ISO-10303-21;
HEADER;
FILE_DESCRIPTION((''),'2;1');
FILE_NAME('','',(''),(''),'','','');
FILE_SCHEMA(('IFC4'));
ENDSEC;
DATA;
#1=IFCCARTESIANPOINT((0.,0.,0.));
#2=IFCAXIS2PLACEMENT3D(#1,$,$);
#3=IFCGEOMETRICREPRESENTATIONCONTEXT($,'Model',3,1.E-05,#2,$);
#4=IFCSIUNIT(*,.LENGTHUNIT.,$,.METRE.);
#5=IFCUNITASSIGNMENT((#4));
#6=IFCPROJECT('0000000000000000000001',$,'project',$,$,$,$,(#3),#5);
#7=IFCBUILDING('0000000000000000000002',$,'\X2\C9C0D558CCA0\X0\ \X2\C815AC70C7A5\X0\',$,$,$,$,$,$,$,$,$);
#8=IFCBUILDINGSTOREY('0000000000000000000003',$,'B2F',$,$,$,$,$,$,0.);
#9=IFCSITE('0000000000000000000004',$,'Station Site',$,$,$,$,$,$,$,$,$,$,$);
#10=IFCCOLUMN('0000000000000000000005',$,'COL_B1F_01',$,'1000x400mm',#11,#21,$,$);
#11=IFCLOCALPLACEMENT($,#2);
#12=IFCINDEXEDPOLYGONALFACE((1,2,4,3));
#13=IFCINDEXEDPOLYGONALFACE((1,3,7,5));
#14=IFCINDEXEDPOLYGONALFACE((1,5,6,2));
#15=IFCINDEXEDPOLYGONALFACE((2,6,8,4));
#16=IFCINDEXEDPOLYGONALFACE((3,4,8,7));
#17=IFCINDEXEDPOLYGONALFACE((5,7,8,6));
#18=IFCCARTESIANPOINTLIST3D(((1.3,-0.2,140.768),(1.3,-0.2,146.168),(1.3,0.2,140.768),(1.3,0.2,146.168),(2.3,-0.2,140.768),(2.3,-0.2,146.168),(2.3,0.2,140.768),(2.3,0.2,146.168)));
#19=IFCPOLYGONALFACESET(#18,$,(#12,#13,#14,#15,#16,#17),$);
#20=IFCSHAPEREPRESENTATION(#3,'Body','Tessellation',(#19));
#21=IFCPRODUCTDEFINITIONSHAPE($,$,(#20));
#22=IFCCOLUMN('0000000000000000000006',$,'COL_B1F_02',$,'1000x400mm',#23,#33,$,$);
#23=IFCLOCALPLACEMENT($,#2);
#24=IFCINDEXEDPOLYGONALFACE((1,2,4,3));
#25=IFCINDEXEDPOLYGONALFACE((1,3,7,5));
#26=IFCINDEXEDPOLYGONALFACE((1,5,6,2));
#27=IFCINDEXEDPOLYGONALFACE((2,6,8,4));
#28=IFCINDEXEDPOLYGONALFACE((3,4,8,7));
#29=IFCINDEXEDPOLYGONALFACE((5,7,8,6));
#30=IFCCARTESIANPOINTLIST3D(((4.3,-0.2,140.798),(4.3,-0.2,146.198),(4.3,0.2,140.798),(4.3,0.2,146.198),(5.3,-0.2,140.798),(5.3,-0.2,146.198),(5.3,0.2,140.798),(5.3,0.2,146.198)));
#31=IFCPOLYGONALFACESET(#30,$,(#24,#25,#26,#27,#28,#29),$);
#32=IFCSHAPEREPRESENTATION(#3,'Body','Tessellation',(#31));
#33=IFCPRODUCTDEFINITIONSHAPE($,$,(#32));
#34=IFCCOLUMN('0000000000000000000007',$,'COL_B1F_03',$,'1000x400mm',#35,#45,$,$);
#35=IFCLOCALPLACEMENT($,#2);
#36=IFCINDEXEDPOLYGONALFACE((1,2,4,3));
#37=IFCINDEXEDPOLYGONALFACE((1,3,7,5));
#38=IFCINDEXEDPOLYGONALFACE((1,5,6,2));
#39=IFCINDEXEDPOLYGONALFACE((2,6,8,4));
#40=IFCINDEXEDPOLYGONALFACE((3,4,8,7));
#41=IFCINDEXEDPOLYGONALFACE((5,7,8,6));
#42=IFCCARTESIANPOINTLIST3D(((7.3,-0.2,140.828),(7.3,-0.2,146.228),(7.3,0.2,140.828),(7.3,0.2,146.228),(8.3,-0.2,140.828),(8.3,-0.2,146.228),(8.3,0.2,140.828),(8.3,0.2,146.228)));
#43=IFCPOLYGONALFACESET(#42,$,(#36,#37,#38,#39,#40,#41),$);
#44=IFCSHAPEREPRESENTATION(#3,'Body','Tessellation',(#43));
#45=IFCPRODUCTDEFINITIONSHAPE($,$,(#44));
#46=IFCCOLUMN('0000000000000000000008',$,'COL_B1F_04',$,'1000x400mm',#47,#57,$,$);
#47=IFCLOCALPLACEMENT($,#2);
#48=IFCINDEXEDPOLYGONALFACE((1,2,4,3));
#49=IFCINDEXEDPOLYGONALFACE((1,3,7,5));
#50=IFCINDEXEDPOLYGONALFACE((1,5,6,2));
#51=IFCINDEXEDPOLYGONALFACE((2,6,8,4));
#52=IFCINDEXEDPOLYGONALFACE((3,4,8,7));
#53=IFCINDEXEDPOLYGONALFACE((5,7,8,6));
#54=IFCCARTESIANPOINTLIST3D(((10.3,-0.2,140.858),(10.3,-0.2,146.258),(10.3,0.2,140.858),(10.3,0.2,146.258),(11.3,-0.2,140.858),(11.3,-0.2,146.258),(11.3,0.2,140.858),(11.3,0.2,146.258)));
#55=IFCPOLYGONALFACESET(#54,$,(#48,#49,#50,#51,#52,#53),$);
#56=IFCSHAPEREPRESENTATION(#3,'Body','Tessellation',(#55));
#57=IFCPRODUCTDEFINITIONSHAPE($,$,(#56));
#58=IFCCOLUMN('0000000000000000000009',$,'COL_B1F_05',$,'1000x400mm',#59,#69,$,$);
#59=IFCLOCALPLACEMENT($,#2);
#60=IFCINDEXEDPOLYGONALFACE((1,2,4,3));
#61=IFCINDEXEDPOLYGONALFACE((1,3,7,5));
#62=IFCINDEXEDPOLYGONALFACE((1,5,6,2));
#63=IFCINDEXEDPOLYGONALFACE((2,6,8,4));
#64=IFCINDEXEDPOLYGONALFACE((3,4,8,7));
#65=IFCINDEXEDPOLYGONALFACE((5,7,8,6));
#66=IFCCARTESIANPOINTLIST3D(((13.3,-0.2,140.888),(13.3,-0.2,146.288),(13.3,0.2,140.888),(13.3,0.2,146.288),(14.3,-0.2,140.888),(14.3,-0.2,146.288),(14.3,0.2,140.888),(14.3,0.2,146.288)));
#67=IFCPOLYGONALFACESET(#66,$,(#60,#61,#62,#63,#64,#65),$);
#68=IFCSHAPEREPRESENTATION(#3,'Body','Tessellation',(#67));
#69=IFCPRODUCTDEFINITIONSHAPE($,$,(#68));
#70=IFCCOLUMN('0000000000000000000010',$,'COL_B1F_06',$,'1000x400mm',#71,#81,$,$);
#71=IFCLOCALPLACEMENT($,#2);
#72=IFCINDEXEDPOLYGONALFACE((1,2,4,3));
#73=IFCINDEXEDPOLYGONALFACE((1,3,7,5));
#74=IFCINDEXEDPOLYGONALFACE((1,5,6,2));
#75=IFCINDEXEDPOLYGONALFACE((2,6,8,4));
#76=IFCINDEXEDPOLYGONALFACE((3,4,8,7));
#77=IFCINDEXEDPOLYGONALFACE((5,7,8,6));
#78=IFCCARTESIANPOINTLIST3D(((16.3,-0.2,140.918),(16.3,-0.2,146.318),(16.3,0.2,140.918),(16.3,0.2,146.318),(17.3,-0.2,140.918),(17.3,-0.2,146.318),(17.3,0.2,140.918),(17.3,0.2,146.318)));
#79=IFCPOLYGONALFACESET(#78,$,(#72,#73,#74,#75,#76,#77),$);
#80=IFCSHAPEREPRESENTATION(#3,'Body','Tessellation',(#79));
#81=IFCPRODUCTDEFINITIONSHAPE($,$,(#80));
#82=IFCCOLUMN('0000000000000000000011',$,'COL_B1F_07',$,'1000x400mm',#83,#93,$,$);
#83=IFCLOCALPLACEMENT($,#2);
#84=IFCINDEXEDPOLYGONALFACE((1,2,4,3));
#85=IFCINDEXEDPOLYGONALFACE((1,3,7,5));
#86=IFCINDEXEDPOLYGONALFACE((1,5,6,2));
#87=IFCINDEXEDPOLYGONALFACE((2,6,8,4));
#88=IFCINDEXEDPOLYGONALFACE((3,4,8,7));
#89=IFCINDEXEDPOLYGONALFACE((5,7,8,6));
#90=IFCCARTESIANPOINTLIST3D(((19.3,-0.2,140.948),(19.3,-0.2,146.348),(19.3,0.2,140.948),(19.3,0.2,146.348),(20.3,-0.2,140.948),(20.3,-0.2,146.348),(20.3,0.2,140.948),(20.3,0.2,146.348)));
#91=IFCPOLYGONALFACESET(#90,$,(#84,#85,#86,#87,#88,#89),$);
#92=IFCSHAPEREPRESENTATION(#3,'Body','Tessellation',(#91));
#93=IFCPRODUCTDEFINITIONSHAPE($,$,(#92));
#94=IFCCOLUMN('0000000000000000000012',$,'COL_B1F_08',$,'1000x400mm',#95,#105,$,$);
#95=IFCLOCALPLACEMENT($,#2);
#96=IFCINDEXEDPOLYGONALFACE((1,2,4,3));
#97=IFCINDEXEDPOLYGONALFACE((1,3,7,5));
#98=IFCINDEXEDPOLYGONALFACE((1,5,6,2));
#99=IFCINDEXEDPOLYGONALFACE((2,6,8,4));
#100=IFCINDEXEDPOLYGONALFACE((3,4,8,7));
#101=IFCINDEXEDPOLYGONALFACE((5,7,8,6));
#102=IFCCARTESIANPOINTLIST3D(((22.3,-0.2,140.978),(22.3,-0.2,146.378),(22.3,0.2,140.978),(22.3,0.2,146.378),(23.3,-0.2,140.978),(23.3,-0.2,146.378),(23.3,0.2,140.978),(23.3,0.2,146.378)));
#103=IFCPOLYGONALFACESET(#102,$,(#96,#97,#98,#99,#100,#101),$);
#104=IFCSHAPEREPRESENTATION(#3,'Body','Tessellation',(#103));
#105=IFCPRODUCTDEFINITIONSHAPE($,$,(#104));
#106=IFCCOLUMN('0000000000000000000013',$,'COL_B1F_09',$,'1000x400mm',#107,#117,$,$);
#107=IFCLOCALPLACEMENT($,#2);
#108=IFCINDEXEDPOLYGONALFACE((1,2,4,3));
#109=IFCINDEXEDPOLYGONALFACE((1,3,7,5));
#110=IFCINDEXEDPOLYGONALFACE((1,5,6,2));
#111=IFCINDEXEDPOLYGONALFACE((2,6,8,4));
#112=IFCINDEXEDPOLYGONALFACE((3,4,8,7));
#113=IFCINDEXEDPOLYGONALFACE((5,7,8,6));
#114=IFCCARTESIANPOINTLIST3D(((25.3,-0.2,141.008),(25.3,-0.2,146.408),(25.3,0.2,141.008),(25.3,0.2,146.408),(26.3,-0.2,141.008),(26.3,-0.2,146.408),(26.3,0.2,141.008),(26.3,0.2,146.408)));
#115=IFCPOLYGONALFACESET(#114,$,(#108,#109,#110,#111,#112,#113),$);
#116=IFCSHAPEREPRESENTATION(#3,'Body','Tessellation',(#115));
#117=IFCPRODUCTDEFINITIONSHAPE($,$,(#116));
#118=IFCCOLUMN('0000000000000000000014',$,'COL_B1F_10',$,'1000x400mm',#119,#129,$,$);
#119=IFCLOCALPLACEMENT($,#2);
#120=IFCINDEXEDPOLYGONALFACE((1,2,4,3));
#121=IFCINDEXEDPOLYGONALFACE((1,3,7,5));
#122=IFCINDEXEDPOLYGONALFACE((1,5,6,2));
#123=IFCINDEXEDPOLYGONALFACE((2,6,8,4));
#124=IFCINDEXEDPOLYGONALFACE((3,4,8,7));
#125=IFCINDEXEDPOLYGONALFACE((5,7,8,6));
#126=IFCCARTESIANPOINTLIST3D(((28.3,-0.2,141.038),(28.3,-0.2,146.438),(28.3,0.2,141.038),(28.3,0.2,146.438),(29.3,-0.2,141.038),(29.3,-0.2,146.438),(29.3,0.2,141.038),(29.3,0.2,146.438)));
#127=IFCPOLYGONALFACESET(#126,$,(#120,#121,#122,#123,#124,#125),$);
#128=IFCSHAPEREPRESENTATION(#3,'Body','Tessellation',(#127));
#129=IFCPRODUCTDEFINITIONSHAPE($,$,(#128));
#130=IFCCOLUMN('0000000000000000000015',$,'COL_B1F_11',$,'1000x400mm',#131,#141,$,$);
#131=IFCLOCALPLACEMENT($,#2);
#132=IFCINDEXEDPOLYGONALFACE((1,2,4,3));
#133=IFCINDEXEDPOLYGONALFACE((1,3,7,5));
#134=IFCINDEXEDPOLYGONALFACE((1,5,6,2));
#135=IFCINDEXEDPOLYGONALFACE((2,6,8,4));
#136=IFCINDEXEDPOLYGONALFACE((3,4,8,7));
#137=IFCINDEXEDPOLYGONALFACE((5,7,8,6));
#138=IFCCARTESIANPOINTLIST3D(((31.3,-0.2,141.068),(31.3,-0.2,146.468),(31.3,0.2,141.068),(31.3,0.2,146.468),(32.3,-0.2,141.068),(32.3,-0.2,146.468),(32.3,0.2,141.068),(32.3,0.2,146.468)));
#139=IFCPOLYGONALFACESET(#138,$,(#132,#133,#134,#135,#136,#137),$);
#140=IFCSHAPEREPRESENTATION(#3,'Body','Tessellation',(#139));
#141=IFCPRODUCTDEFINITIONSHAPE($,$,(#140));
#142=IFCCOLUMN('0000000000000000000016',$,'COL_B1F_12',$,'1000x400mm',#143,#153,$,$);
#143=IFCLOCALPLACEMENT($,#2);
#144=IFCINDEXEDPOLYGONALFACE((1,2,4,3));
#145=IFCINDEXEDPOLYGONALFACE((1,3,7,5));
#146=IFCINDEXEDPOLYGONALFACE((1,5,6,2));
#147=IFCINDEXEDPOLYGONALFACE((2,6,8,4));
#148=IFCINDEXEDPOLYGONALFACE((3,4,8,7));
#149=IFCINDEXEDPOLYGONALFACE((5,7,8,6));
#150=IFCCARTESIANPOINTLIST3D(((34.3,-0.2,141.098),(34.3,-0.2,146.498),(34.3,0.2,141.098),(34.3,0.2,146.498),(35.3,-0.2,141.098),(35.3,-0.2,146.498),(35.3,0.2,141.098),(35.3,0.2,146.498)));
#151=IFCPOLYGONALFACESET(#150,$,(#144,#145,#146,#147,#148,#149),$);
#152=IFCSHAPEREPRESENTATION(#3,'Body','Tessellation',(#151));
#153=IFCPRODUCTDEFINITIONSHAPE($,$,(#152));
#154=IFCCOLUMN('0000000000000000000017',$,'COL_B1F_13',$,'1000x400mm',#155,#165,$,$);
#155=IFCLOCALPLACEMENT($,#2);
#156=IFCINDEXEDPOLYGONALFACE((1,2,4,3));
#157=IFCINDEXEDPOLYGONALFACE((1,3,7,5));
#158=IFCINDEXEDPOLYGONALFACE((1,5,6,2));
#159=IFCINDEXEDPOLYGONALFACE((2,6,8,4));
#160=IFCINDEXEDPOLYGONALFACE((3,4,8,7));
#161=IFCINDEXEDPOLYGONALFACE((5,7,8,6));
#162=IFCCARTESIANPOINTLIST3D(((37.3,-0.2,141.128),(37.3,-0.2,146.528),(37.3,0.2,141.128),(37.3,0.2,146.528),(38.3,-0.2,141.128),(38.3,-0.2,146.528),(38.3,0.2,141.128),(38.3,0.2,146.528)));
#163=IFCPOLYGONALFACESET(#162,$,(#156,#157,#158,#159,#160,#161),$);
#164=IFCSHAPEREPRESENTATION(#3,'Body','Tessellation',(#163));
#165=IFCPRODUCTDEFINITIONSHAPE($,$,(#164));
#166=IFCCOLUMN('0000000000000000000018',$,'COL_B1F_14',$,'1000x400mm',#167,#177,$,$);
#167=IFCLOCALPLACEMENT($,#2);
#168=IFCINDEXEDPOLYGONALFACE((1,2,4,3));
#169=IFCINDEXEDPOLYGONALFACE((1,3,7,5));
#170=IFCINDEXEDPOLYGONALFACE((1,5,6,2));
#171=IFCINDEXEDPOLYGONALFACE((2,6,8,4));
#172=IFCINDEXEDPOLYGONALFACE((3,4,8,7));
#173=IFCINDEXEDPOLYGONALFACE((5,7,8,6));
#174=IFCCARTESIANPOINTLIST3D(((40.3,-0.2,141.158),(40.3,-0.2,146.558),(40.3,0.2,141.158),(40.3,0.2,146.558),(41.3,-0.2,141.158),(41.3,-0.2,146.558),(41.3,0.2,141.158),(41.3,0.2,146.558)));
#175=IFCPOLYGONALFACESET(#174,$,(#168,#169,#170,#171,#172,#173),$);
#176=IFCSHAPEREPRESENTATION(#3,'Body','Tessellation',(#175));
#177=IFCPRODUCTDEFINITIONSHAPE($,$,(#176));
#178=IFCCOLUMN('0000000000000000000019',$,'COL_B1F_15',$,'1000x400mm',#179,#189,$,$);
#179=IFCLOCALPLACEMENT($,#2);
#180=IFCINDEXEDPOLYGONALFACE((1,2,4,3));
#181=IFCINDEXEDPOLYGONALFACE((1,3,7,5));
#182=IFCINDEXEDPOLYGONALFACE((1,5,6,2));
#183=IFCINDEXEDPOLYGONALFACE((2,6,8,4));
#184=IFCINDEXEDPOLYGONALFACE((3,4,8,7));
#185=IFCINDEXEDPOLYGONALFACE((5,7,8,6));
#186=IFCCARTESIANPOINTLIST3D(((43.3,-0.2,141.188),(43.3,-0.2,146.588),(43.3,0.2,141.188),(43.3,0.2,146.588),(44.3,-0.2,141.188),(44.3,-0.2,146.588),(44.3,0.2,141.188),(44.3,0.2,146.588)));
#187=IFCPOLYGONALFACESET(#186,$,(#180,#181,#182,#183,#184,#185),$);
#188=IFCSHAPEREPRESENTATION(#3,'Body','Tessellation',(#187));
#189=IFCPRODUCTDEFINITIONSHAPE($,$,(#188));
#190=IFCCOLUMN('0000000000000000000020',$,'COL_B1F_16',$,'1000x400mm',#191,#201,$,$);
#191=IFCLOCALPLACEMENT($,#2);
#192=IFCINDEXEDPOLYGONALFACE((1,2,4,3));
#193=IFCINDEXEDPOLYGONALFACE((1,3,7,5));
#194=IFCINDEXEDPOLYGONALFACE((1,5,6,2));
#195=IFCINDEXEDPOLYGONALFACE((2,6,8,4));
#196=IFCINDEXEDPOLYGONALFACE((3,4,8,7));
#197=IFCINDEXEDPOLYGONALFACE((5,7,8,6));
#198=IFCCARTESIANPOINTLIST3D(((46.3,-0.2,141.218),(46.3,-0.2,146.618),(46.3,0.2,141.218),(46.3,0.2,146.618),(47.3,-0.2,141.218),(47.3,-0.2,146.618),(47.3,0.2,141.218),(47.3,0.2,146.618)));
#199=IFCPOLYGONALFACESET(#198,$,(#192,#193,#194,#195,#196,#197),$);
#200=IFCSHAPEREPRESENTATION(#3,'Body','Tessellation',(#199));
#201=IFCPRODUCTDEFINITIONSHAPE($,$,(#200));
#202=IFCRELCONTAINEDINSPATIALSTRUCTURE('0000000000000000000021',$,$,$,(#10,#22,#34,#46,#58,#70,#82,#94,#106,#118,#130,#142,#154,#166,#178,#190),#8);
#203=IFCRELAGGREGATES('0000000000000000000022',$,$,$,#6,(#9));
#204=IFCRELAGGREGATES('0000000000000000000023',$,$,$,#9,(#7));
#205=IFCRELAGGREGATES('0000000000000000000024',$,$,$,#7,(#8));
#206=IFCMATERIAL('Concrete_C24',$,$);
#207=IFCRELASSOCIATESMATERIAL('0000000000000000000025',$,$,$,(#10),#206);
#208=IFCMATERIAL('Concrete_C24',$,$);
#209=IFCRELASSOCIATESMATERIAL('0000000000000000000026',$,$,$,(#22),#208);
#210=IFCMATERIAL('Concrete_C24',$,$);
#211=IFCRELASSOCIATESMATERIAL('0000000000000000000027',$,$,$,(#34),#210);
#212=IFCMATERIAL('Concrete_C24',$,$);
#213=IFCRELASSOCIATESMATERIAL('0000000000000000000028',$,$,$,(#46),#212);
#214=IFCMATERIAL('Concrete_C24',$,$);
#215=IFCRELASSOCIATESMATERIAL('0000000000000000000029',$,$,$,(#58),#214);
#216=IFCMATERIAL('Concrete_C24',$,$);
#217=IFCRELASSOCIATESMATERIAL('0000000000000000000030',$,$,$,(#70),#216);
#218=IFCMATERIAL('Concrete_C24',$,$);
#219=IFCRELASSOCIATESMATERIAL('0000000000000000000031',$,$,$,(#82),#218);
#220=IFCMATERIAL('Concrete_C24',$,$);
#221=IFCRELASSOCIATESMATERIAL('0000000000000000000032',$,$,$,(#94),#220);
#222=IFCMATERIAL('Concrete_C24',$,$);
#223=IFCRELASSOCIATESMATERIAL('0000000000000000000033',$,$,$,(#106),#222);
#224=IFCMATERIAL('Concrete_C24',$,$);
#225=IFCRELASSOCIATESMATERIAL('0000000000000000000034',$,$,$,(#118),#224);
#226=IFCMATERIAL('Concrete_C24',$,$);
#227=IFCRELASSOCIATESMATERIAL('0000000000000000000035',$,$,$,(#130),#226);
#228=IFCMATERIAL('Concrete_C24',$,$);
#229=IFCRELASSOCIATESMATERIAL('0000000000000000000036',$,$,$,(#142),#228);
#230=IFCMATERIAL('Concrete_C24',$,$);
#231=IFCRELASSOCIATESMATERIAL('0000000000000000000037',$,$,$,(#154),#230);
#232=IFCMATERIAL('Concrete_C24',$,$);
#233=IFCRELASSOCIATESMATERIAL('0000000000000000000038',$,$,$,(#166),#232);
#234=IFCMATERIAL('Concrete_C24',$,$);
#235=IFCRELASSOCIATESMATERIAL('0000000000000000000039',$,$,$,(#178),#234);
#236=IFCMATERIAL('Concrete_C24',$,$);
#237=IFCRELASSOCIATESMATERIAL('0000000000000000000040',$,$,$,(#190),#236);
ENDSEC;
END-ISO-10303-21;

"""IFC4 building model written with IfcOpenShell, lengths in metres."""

from ifc_helpers import new_model, si_unit, frame, origin, place, context, project, spatial, rectangle, extrude, material, element, save


model = new_model("IFC4")

# Units and contexts
model_context = context("Model", 3, precision=1e-05, world=origin())
ifc_project = project(units=[si_unit("LENGTHUNIT", "METRE")], contexts=[model_context])

# Site, building, storey
site = spatial("IfcSite", under=ifc_project, Name="Station Site")
building = spatial("IfcBuilding", under=site, Name="지하철 정거장")
storey = spatial("IfcBuildingStorey", under=building, Name="B2F", Elevation=0.0)

# Columns
ifc_material_1 = material(Name="Concrete_C24")
column_1_placement = place(None, frame((1.8, 0.0, 140.768)))
element("IfcColumn", 1, at=column_1_placement, inside=storey, material=ifc_material_1, Name="COL_B1F_01", ObjectType="1000x400mm", context=model_context, shape_type="SweptSolid", body=[
    extrude(rectangle(XDim=1.0, YDim=0.4), origin(), (0.0, 0.0, 1.0), 5.4),
])
ifc_material_2 = material(Name="Concrete_C24")
column_2_placement = place(None, frame((4.8, 0.0, 140.798)))
element("IfcColumn", 2, at=column_2_placement, inside=storey, material=ifc_material_2, Name="COL_B1F_02", ObjectType="1000x400mm", context=model_context, shape_type="SweptSolid", body=[
    extrude(rectangle(XDim=1.0, YDim=0.4), origin(), (0.0, 0.0, 1.0), 5.4),
])
ifc_material_3 = material(Name="Concrete_C24")
column_3_placement = place(None, frame((7.8, 0.0, 140.828)))
element("IfcColumn", 3, at=column_3_placement, inside=storey, material=ifc_material_3, Name="COL_B1F_03", ObjectType="1000x400mm", context=model_context, shape_type="SweptSolid", body=[
    extrude(rectangle(XDim=1.0, YDim=0.4), origin(), (0.0, 0.0, 1.0), 5.4),
])
ifc_material_4 = material(Name="Concrete_C24")
column_4_placement = place(None, frame((10.8, 0.0, 140.858)))
element("IfcColumn", 4, at=column_4_placement, inside=storey, material=ifc_material_4, Name="COL_B1F_04", ObjectType="1000x400mm", context=model_context, shape_type="SweptSolid", body=[
    extrude(rectangle(XDim=1.0, YDim=0.4), origin(), (0.0, 0.0, 1.0), 5.4),
])
ifc_material_5 = material(Name="Concrete_C24")
column_5_placement = place(None, frame((13.8, 0.0, 140.888)))
element("IfcColumn", 5, at=column_5_placement, inside=storey, material=ifc_material_5, Name="COL_B1F_05", ObjectType="1000x400mm", context=model_context, shape_type="SweptSolid", body=[
    extrude(rectangle(XDim=1.0, YDim=0.4), origin(), (0.0, 0.0, 1.0), 5.4),
])
ifc_material_6 = material(Name="Concrete_C24")
column_6_placement = place(None, frame((16.8, 0.0, 140.918)))
element("IfcColumn", 6, at=column_6_placement, inside=storey, material=ifc_material_6, Name="COL_B1F_06", ObjectType="1000x400mm", context=model_context, shape_type="SweptSolid", body=[
    extrude(rectangle(XDim=1.0, YDim=0.4), origin(), (0.0, 0.0, 1.0), 5.4),
])
ifc_material_7 = material(Name="Concrete_C24")
column_7_placement = place(None, frame((19.8, 0.0, 140.948)))
element("IfcColumn", 7, at=column_7_placement, inside=storey, material=ifc_material_7, Name="COL_B1F_07", ObjectType="1000x400mm", context=model_context, shape_type="SweptSolid", body=[
    extrude(rectangle(XDim=1.0, YDim=0.4), origin(), (0.0, 0.0, 1.0), 5.4),
])
ifc_material_8 = material(Name="Concrete_C24")
column_8_placement = place(None, frame((22.8, 0.0, 140.978)))
element("IfcColumn", 8, at=column_8_placement, inside=storey, material=ifc_material_8, Name="COL_B1F_08", ObjectType="1000x400mm", context=model_context, shape_type="SweptSolid", body=[
    extrude(rectangle(XDim=1.0, YDim=0.4), origin(), (0.0, 0.0, 1.0), 5.4),
])
ifc_material_9 = material(Name="Concrete_C24")
column_9_placement = place(None, frame((25.8, 0.0, 141.008)))
element("IfcColumn", 9, at=column_9_placement, inside=storey, material=ifc_material_9, Name="COL_B1F_09", ObjectType="1000x400mm", context=model_context, shape_type="SweptSolid", body=[
    extrude(rectangle(XDim=1.0, YDim=0.4), origin(), (0.0, 0.0, 1.0), 5.4),
])
ifc_material_10 = material(Name="Concrete_C24")
column_10_placement = place(None, frame((28.8, 0.0, 141.038)))
element("IfcColumn", 10, at=column_10_placement, inside=storey, material=ifc_material_10, Name="COL_B1F_10", ObjectType="1000x400mm", context=model_context, shape_type="SweptSolid", body=[
    extrude(rectangle(XDim=1.0, YDim=0.4), origin(), (0.0, 0.0, 1.0), 5.4),
])
ifc_material_11 = material(Name="Concrete_C24")
column_11_placement = place(None, frame((31.8, 0.0, 141.068)))
element("IfcColumn", 11, at=column_11_placement, inside=storey, material=ifc_material_11, Name="COL_B1F_11", ObjectType="1000x400mm", context=model_context, shape_type="SweptSolid", body=[
    extrude(rectangle(XDim=1.0, YDim=0.4), origin(), (0.0, 0.0, 1.0), 5.4),
])
ifc_material_12 = material(Name="Concrete_C24")
column_12_placement = place(None, frame((34.8, 0.0, 141.098)))
element("IfcColumn", 12, at=column_12_placement, inside=storey, material=ifc_material_12, Name="COL_B1F_12", ObjectType="1000x400mm", context=model_context, shape_type="SweptSolid", body=[
    extrude(rectangle(XDim=1.0, YDim=0.4), origin(), (0.0, 0.0, 1.0), 5.4),
])
ifc_material_13 = material(Name="Concrete_C24")
column_13_placement = place(None, frame((37.8, 0.0, 141.128)))
element("IfcColumn", 13, at=column_13_placement, inside=storey, material=ifc_material_13, Name="COL_B1F_13", ObjectType="1000x400mm", context=model_context, shape_type="SweptSolid", body=[
    extrude(rectangle(XDim=1.0, YDim=0.4), origin(), (0.0, 0.0, 1.0), 5.4),
])
ifc_material_14 = material(Name="Concrete_C24")
column_14_placement = place(None, frame((40.8, 0.0, 141.158)))
element("IfcColumn", 14, at=column_14_placement, inside=storey, material=ifc_material_14, Name="COL_B1F_14", ObjectType="1000x400mm", context=model_context, shape_type="SweptSolid", body=[
    extrude(rectangle(XDim=1.0, YDim=0.4), origin(), (0.0, 0.0, 1.0), 5.4),
])
ifc_material_15 = material(Name="Concrete_C24")
column_15_placement = place(None, frame((43.8, 0.0, 141.188)))
element("IfcColumn", 15, at=column_15_placement, inside=storey, material=ifc_material_15, Name="COL_B1F_15", ObjectType="1000x400mm", context=model_context, shape_type="SweptSolid", body=[
    extrude(rectangle(XDim=1.0, YDim=0.4), origin(), (0.0, 0.0, 1.0), 5.4),
])
ifc_material_16 = material(Name="Concrete_C24")
column_16_placement = place(None, frame((46.8, 0.0, 141.218)))
element("IfcColumn", 16, at=column_16_placement, inside=storey, material=ifc_material_16, Name="COL_B1F_16", ObjectType="1000x400mm", context=model_context, shape_type="SweptSolid", body=[
    extrude(rectangle(XDim=1.0, YDim=0.4), origin(), (0.0, 0.0, 1.0), 5.4),
])

save(model, "model.ifc")
